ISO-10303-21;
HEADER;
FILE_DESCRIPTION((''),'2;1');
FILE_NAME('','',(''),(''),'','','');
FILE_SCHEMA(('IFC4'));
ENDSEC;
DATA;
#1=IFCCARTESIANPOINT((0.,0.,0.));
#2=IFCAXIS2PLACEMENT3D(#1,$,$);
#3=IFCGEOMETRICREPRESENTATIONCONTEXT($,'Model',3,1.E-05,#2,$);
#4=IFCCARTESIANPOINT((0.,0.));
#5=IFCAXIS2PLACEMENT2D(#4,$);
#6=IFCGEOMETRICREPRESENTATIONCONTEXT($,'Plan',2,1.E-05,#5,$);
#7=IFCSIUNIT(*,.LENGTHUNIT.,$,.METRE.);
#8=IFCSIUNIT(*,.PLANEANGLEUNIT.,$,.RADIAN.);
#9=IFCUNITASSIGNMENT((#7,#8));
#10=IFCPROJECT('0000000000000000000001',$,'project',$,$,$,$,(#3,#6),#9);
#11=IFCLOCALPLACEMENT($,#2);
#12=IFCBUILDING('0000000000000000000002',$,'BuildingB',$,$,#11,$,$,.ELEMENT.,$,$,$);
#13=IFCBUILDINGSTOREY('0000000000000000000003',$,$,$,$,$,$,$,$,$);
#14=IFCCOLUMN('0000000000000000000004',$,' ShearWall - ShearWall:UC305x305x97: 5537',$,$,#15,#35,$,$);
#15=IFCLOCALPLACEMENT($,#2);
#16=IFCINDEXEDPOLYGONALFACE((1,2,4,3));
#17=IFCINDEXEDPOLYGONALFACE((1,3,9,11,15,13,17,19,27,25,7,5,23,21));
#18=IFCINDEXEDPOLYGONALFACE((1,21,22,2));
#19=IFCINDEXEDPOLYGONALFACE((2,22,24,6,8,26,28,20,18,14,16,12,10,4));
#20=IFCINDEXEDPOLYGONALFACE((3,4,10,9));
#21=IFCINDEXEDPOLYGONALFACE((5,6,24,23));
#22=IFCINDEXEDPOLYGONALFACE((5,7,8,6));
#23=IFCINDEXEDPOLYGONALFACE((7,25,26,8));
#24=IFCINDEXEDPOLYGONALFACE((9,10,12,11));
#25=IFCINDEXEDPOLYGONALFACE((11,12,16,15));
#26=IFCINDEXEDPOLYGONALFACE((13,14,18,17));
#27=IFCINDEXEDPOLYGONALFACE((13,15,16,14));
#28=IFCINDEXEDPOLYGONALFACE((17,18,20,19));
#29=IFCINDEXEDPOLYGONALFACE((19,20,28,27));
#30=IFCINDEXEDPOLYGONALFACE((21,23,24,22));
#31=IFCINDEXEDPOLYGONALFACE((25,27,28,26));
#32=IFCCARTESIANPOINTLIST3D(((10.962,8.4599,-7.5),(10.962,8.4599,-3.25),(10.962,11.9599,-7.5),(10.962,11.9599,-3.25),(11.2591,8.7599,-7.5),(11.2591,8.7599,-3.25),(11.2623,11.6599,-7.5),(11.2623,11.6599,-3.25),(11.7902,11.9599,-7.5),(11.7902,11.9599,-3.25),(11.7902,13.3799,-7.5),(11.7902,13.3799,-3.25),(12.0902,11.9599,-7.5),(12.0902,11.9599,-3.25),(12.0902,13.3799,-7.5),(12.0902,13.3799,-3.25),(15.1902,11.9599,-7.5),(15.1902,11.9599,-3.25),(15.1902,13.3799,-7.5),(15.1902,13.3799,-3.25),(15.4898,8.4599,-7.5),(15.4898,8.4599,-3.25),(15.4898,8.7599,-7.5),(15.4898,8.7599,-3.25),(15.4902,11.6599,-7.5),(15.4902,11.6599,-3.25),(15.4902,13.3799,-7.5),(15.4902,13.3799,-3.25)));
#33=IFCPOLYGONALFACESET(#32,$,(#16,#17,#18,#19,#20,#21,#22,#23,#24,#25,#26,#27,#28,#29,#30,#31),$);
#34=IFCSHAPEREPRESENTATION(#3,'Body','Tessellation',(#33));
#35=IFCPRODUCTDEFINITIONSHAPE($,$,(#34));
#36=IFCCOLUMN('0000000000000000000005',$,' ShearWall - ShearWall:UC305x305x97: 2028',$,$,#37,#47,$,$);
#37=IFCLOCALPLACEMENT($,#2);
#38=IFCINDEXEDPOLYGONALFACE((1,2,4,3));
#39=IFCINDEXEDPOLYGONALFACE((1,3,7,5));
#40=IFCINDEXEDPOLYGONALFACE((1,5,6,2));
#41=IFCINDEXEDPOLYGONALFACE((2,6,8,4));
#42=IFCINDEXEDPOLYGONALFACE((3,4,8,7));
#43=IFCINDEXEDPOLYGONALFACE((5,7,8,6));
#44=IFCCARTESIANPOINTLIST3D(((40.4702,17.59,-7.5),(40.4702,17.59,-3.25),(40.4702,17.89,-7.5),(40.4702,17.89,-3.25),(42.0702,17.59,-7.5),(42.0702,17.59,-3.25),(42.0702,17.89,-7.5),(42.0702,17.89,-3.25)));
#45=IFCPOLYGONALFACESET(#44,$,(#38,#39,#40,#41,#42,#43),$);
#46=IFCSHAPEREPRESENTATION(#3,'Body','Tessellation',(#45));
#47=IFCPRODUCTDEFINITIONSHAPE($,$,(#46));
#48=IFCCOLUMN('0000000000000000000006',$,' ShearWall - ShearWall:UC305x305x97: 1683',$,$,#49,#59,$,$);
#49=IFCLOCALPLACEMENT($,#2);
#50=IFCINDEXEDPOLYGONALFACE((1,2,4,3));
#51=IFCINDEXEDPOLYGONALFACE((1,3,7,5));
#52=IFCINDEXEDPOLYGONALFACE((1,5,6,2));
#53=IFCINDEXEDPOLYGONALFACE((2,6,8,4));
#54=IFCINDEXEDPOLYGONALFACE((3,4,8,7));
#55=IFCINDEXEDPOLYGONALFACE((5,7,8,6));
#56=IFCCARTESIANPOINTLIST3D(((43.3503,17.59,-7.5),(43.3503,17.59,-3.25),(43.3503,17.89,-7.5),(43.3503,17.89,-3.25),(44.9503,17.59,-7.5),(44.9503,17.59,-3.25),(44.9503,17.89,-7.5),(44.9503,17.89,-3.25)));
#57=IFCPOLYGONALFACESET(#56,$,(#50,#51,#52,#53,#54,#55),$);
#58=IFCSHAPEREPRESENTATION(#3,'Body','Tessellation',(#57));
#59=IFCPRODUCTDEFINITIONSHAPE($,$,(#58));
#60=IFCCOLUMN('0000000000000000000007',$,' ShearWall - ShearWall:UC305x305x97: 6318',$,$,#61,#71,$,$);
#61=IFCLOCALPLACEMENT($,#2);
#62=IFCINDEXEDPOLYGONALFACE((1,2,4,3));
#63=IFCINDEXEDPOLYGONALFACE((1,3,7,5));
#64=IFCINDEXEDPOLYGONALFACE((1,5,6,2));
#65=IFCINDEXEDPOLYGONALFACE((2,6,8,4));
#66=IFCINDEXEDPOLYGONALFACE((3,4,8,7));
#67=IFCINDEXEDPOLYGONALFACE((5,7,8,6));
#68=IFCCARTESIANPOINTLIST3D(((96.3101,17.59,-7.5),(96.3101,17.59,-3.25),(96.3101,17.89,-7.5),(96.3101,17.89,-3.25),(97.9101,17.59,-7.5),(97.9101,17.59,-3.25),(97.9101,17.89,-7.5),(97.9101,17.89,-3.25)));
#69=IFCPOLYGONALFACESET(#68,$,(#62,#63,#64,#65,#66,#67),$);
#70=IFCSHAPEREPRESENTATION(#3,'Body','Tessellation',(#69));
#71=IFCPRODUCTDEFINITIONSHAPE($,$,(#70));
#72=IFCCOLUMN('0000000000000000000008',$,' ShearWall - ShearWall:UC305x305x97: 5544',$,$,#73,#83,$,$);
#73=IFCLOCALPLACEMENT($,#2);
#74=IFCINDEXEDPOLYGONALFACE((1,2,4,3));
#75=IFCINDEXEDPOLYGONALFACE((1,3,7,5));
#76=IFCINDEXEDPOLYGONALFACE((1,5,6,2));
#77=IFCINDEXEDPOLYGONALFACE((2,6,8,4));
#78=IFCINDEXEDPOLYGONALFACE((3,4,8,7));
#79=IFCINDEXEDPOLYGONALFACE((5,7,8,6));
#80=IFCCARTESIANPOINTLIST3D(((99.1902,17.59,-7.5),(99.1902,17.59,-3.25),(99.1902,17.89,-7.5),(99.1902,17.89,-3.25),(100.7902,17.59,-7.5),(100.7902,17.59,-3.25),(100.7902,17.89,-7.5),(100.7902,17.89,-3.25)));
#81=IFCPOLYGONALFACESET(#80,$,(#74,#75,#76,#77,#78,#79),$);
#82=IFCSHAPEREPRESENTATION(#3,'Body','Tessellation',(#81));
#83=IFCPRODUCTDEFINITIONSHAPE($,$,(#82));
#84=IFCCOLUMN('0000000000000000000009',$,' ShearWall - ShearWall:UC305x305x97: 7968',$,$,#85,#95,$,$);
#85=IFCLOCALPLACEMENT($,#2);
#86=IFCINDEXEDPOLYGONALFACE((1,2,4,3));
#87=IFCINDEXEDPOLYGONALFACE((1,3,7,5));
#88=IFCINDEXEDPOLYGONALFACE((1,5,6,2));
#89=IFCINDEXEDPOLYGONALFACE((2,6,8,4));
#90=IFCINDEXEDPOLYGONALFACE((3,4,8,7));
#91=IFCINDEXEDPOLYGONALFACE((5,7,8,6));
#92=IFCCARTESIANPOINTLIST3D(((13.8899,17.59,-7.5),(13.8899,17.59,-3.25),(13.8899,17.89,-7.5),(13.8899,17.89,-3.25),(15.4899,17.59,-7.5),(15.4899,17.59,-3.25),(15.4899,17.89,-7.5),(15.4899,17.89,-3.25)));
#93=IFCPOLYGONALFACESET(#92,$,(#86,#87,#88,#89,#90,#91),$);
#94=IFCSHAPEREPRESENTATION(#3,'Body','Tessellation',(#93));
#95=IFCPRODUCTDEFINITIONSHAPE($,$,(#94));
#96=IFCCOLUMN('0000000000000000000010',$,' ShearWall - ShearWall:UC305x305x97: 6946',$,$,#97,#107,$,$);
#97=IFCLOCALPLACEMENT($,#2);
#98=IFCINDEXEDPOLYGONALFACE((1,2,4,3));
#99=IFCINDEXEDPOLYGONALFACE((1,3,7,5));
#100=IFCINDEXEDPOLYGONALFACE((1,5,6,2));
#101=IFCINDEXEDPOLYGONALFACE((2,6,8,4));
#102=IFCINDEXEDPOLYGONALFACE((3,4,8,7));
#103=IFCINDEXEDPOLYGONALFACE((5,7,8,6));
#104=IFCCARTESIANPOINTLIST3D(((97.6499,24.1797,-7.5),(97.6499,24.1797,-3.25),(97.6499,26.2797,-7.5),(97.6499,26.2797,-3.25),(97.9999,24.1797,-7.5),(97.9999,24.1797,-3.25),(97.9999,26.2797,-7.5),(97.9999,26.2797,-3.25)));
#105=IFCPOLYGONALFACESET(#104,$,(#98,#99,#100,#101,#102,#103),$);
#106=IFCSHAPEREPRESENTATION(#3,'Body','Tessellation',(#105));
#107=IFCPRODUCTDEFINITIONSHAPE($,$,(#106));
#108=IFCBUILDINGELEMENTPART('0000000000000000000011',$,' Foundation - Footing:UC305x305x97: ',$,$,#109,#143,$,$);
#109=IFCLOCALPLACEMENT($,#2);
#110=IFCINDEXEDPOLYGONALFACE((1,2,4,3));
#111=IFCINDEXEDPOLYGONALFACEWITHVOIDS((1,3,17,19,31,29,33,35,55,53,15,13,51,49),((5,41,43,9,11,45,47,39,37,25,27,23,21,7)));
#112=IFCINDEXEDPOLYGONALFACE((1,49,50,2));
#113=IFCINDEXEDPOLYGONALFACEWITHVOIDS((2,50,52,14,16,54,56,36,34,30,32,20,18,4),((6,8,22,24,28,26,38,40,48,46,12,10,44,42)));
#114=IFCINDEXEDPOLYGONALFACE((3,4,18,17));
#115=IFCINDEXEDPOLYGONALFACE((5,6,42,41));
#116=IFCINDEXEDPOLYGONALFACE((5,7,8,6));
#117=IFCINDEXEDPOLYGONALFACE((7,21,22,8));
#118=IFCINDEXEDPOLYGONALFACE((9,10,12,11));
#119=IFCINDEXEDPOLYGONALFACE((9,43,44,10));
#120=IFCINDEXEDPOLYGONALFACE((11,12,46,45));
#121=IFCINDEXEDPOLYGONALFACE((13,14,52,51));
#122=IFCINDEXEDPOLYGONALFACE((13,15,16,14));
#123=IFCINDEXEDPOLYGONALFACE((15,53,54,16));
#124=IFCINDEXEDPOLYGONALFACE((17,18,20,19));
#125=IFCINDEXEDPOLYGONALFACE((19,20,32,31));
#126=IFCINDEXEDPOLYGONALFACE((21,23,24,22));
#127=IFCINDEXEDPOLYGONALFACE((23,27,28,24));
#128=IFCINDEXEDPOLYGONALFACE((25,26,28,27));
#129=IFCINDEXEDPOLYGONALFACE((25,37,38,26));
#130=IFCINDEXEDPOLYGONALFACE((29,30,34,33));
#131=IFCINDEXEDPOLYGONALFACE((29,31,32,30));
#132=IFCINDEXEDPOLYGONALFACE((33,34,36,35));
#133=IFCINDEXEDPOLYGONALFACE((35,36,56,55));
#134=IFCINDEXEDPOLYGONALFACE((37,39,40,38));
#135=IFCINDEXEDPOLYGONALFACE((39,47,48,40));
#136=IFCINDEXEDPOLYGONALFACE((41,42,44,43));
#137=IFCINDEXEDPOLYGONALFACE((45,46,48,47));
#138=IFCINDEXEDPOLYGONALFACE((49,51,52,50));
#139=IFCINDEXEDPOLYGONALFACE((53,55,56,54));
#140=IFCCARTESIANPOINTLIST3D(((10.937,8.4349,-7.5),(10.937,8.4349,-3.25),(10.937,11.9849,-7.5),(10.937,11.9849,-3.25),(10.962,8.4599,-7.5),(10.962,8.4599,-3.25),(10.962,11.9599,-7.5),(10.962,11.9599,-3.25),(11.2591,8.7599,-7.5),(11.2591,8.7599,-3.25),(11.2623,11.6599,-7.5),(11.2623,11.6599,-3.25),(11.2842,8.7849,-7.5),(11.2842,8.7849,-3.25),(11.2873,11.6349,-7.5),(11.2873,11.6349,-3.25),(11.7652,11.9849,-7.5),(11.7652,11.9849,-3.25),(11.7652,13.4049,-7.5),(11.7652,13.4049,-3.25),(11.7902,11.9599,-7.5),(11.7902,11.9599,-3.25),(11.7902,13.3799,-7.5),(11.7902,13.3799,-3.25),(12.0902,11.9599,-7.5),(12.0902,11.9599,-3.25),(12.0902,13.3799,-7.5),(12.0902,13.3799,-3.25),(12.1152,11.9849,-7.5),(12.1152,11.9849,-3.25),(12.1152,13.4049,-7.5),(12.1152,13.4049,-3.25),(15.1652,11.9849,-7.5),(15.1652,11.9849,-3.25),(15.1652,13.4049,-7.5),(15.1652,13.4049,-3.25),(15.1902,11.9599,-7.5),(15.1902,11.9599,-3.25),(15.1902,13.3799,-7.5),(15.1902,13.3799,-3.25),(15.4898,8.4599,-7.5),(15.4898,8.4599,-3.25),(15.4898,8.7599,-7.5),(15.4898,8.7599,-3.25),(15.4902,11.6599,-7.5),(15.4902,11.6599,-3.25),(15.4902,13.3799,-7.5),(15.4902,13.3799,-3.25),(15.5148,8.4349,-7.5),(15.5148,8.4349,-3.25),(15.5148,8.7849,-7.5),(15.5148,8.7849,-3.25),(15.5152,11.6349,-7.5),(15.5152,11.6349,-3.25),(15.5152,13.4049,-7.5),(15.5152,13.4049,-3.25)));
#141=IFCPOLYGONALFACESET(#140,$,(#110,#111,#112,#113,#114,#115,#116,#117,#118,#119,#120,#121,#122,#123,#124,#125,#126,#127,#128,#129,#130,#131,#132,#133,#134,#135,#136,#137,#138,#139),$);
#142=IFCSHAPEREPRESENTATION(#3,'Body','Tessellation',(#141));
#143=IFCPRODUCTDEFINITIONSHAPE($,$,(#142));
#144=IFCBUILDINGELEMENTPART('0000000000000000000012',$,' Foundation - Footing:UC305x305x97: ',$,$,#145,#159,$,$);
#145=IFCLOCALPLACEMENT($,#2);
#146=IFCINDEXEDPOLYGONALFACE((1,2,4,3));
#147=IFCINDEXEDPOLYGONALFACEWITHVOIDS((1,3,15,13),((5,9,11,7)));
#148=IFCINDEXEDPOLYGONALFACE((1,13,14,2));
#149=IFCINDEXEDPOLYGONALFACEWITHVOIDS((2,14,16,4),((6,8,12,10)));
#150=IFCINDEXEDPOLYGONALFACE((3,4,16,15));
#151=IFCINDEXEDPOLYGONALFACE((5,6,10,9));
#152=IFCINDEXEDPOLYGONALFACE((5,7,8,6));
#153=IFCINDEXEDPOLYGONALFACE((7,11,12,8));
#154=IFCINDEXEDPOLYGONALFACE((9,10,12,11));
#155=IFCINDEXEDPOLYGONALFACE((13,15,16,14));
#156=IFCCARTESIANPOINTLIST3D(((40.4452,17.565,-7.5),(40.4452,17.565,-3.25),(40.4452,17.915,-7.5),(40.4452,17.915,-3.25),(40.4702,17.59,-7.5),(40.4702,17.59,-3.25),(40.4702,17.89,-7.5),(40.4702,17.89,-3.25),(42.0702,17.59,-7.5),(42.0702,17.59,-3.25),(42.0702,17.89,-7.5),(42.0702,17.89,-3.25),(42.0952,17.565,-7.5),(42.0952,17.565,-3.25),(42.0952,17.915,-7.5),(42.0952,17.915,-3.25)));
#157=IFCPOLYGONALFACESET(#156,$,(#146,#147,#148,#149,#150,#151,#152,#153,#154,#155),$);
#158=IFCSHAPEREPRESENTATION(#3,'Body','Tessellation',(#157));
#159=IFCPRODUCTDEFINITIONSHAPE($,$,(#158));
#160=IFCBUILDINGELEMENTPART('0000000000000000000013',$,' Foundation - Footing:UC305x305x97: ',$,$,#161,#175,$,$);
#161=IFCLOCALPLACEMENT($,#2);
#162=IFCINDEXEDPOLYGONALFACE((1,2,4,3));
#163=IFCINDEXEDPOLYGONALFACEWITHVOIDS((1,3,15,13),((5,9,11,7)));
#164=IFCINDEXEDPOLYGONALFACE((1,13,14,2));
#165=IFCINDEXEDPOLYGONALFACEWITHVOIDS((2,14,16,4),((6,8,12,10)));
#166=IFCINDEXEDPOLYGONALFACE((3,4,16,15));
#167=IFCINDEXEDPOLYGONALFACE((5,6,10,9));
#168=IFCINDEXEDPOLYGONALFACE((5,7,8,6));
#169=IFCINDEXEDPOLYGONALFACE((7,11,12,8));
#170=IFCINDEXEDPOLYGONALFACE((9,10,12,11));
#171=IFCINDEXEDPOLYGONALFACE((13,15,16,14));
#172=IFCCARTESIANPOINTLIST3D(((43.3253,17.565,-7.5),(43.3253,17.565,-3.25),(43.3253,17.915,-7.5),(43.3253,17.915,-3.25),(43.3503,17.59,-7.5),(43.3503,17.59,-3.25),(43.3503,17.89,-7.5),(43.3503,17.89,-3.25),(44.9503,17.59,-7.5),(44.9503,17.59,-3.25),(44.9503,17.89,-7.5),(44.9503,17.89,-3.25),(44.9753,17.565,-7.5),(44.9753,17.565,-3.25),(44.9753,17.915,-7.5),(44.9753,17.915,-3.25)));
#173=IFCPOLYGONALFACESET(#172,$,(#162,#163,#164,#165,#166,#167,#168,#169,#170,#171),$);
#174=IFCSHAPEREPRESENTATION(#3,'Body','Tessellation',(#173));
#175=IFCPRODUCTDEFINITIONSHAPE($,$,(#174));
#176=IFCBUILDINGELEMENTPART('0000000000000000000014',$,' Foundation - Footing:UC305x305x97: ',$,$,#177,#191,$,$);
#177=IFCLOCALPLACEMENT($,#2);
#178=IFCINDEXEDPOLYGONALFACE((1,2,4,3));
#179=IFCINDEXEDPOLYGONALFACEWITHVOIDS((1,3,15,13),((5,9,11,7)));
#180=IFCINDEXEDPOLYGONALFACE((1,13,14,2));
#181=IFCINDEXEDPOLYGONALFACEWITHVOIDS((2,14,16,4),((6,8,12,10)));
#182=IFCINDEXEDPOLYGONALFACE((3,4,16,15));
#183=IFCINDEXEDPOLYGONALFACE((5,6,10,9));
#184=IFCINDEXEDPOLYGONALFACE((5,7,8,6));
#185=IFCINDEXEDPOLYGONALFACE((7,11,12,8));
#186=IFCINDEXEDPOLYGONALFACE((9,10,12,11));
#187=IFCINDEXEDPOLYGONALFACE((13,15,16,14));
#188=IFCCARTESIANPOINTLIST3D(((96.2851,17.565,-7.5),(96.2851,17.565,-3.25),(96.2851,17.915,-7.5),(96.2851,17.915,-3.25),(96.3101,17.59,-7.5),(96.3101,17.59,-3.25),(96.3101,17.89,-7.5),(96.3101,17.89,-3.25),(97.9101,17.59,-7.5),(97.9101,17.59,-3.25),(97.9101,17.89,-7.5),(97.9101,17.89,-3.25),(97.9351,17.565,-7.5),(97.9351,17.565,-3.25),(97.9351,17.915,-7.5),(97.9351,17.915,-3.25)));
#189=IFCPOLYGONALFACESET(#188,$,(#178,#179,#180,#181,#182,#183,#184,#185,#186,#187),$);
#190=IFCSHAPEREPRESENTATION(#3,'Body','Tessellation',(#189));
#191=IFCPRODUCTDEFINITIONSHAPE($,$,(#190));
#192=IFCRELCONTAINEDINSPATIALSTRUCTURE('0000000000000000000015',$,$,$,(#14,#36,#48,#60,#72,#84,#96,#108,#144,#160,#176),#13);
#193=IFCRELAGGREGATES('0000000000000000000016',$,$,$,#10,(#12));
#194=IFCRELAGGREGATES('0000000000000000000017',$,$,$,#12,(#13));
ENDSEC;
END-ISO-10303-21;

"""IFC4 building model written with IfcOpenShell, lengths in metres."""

from ifc_helpers import new_model, si_unit, origin, origin_with_axes, origin_2d, place, context, project, spatial, polyline, outline, extrude, element, save


model = new_model("IFC4")

# Units and contexts
model_context = context("Model", 3, precision=1e-05, world=origin())
plan_context = context("Plan", 2, precision=1e-05, world=origin_2d())
ifc_project = project(units=[si_unit("LENGTHUNIT", "METRE"), si_unit("PLANEANGLEUNIT", "RADIAN")], contexts=[model_context, plan_context])

# Building, storey
building_placement = place(None, origin())
building = spatial("IfcBuilding", under=ifc_project, at=building_placement, Name="BuildingB", CompositionType="ELEMENT")
storey = spatial("IfcBuildingStorey", under=building)

# Columns
column_1_placement = place(None, origin_with_axes())
element("IfcColumn", 1, at=column_1_placement, inside=storey, Name=" ShearWall - ShearWall:UC305x305x97: 5537", context=model_context, shape_type="SweptSolid", body=[
    extrude(outline(polyline([(10.962, 8.4599, -7.5), (15.4898, 8.4599, -7.5), (15.4898, 8.7599, -7.5), (11.2591, 8.7599, -7.5), (11.2623, 11.6599, -7.5), (15.4902, 11.6599, -7.5), (15.4902, 13.3799, -7.5), (15.1902, 13.3799, -7.5), (15.1902, 11.9599, -7.5), (12.0902, 11.9599, -7.5), (12.0902, 13.3799, -7.5), (11.7902, 13.3799, -7.5), (11.7902, 11.9599, -7.5), (10.962, 11.9599, -7.5), (10.962, 8.4599, -7.5)])), None, (0.0, 0.0, 1.0), 4.25),
])
column_2_placement = place(None, origin_with_axes())
element("IfcColumn", 2, at=column_2_placement, inside=storey, Name=" ShearWall - ShearWall:UC305x305x97: 2028", context=model_context, shape_type="SweptSolid", body=[
    extrude(outline(polyline([(42.0702, 17.59, -7.5), (42.0702, 17.89, -7.5), (40.4702, 17.89, -7.5), (40.4702, 17.59, -7.5), (42.0702, 17.59, -7.5)])), None, (0.0, 0.0, 1.0), 4.25),
])
column_3_placement = place(None, origin_with_axes())
element("IfcColumn", 3, at=column_3_placement, inside=storey, Name=" ShearWall - ShearWall:UC305x305x97: 1683", context=model_context, shape_type="SweptSolid", body=[
    extrude(outline(polyline([(44.9503, 17.59, -7.5), (44.9503, 17.89, -7.5), (43.3503, 17.89, -7.5), (43.3503, 17.59, -7.5), (44.9503, 17.59, -7.5)])), None, (0.0, 0.0, 1.0), 4.25),
])
column_4_placement = place(None, origin_with_axes())
element("IfcColumn", 4, at=column_4_placement, inside=storey, Name=" ShearWall - ShearWall:UC305x305x97: 6318", context=model_context, shape_type="SweptSolid", body=[
    extrude(outline(polyline([(97.9101, 17.59, -7.5), (97.9101, 17.89, -7.5), (96.3101, 17.89, -7.5), (96.3101, 17.59, -7.5), (97.9101, 17.59, -7.5)])), None, (0.0, 0.0, 1.0), 4.25),
])
column_5_placement = place(None, origin_with_axes())
element("IfcColumn", 5, at=column_5_placement, inside=storey, Name=" ShearWall - ShearWall:UC305x305x97: 5544", context=model_context, shape_type="SweptSolid", body=[
    extrude(outline(polyline([(100.7902, 17.59, -7.5), (100.7902, 17.89, -7.5), (99.1902, 17.89, -7.5), (99.1902, 17.59, -7.5), (100.7902, 17.59, -7.5)])), None, (0.0, 0.0, 1.0), 4.25),
])
column_6_placement = place(None, origin_with_axes())
element("IfcColumn", 6, at=column_6_placement, inside=storey, Name=" ShearWall - ShearWall:UC305x305x97: 7968", context=model_context, shape_type="SweptSolid", body=[
    extrude(outline(polyline([(13.8899, 17.59, -7.5), (13.8899, 17.89, -7.5), (15.4899, 17.89, -7.5), (15.4899, 17.59, -7.5), (13.8899, 17.59, -7.5)])), None, (0.0, 0.0, 1.0), 4.25),
])
column_7_placement = place(None, origin_with_axes())
element("IfcColumn", 7, at=column_7_placement, inside=storey, Name=" ShearWall - ShearWall:UC305x305x97: 6946", context=model_context, shape_type="SweptSolid", body=[
    extrude(outline(polyline([(97.6499, 26.2797, -7.5), (97.9999, 26.2797, -7.5), (97.9999, 24.1797, -7.5), (97.6499, 24.1797, -7.5), (97.6499, 26.2797, -7.5)])), None, (0.0, 0.0, 1.0), 4.25),
])

# Building element parts, openings
building_element_part_1 = element("IfcBuildingElementPart", 8, inside=storey, Name=" Foundation - Footing:UC305x305x97: ", context=model_context, shape_type="SweptSolid", body=[
    extrude(outline(polyline([(10.937, 8.4349, -7.5), (15.5148, 8.4349, -7.5), (15.5148, 8.7849, -7.5), (11.2842, 8.7849, -7.5), (11.2873, 11.6349, -7.5), (15.5152, 11.6349, -7.5), (15.5152, 13.4049, -7.5), (15.1652, 13.4049, -7.5), (15.1652, 11.9849, -7.5), (12.1152, 11.9849, -7.5), (12.1152, 13.4049, -7.5), (11.7652, 13.4049, -7.5), (11.7652, 11.9849, -7.5), (10.937, 11.9849, -7.5), (10.937, 8.4349, -7.5)])), None, (0.0, 0.0, 1.0), 4.25),
])
element("IfcOpeningElement", 9, inside=storey, cuts=building_element_part_1, context=model_context, shape_type="SweptSolid", body=[
    extrude(outline(polyline([(10.962, 8.4599, -7.5), (15.4898, 8.4599, -7.5), (15.4898, 8.7599, -7.5), (11.2591, 8.7599, -7.5), (11.2623, 11.6599, -7.5), (15.4902, 11.6599, -7.5), (15.4902, 13.3799, -7.5), (15.1902, 13.3799, -7.5), (15.1902, 11.9599, -7.5), (12.0902, 11.9599, -7.5), (12.0902, 13.3799, -7.5), (11.7902, 13.3799, -7.5), (11.7902, 11.9599, -7.5), (10.962, 11.9599, -7.5), (10.962, 8.4599, -7.5)])), None, (0.0, 0.0, 1.0), 4.25),
])
building_element_part_2 = element("IfcBuildingElementPart", 10, inside=storey, Name=" Foundation - Footing:UC305x305x97: ", context=model_context, shape_type="SweptSolid", body=[
    extrude(outline(polyline([(42.0952, 17.565, -7.5), (42.0952, 17.915, -7.5), (40.4452, 17.915, -7.5), (40.4452, 17.565, -7.5), (42.0952, 17.565, -7.5)])), None, (0.0, 0.0, 1.0), 4.25),
])
element("IfcOpeningElement", 11, inside=storey, cuts=building_element_part_2, context=model_context, shape_type="SweptSolid", body=[
    extrude(outline(polyline([(42.0702, 17.59, -7.5), (42.0702, 17.89, -7.5), (40.4702, 17.89, -7.5), (40.4702, 17.59, -7.5), (42.0702, 17.59, -7.5)])), None, (0.0, 0.0, 1.0), 4.25),
])
building_element_part_3 = element("IfcBuildingElementPart", 12, inside=storey, Name=" Foundation - Footing:UC305x305x97: ", context=model_context, shape_type="SweptSolid", body=[
    extrude(outline(polyline([(44.9753, 17.565, -7.5), (44.9753, 17.915, -7.5), (43.3253, 17.915, -7.5), (43.3253, 17.565, -7.5), (44.9753, 17.565, -7.5)])), None, (0.0, 0.0, 1.0), 4.25),
])
element("IfcOpeningElement", 13, inside=storey, cuts=building_element_part_3, context=model_context, shape_type="SweptSolid", body=[
    extrude(outline(polyline([(44.9503, 17.59, -7.5), (44.9503, 17.89, -7.5), (43.3503, 17.89, -7.5), (43.3503, 17.59, -7.5), (44.9503, 17.59, -7.5)])), None, (0.0, 0.0, 1.0), 4.25),
])
building_element_part_4 = element("IfcBuildingElementPart", 14, inside=storey, Name=" Foundation - Footing:UC305x305x97: ", context=model_context, shape_type="SweptSolid", body=[
    extrude(outline(polyline([(97.9351, 17.565, -7.5), (97.9351, 17.915, -7.5), (96.2851, 17.915, -7.5), (96.2851, 17.565, -7.5), (97.9351, 17.565, -7.5)])), None, (0.0, 0.0, 1.0), 4.25),
])
element("IfcOpeningElement", 15, inside=storey, cuts=building_element_part_4, context=model_context, shape_type="SweptSolid", body=[
    extrude(outline(polyline([(97.9101, 17.59, -7.5), (97.9101, 17.89, -7.5), (96.3101, 17.89, -7.5), (96.3101, 17.59, -7.5), (97.9101, 17.59, -7.5)])), None, (0.0, 0.0, 1.0), 4.25),
])

save(model, "model.ifc")
